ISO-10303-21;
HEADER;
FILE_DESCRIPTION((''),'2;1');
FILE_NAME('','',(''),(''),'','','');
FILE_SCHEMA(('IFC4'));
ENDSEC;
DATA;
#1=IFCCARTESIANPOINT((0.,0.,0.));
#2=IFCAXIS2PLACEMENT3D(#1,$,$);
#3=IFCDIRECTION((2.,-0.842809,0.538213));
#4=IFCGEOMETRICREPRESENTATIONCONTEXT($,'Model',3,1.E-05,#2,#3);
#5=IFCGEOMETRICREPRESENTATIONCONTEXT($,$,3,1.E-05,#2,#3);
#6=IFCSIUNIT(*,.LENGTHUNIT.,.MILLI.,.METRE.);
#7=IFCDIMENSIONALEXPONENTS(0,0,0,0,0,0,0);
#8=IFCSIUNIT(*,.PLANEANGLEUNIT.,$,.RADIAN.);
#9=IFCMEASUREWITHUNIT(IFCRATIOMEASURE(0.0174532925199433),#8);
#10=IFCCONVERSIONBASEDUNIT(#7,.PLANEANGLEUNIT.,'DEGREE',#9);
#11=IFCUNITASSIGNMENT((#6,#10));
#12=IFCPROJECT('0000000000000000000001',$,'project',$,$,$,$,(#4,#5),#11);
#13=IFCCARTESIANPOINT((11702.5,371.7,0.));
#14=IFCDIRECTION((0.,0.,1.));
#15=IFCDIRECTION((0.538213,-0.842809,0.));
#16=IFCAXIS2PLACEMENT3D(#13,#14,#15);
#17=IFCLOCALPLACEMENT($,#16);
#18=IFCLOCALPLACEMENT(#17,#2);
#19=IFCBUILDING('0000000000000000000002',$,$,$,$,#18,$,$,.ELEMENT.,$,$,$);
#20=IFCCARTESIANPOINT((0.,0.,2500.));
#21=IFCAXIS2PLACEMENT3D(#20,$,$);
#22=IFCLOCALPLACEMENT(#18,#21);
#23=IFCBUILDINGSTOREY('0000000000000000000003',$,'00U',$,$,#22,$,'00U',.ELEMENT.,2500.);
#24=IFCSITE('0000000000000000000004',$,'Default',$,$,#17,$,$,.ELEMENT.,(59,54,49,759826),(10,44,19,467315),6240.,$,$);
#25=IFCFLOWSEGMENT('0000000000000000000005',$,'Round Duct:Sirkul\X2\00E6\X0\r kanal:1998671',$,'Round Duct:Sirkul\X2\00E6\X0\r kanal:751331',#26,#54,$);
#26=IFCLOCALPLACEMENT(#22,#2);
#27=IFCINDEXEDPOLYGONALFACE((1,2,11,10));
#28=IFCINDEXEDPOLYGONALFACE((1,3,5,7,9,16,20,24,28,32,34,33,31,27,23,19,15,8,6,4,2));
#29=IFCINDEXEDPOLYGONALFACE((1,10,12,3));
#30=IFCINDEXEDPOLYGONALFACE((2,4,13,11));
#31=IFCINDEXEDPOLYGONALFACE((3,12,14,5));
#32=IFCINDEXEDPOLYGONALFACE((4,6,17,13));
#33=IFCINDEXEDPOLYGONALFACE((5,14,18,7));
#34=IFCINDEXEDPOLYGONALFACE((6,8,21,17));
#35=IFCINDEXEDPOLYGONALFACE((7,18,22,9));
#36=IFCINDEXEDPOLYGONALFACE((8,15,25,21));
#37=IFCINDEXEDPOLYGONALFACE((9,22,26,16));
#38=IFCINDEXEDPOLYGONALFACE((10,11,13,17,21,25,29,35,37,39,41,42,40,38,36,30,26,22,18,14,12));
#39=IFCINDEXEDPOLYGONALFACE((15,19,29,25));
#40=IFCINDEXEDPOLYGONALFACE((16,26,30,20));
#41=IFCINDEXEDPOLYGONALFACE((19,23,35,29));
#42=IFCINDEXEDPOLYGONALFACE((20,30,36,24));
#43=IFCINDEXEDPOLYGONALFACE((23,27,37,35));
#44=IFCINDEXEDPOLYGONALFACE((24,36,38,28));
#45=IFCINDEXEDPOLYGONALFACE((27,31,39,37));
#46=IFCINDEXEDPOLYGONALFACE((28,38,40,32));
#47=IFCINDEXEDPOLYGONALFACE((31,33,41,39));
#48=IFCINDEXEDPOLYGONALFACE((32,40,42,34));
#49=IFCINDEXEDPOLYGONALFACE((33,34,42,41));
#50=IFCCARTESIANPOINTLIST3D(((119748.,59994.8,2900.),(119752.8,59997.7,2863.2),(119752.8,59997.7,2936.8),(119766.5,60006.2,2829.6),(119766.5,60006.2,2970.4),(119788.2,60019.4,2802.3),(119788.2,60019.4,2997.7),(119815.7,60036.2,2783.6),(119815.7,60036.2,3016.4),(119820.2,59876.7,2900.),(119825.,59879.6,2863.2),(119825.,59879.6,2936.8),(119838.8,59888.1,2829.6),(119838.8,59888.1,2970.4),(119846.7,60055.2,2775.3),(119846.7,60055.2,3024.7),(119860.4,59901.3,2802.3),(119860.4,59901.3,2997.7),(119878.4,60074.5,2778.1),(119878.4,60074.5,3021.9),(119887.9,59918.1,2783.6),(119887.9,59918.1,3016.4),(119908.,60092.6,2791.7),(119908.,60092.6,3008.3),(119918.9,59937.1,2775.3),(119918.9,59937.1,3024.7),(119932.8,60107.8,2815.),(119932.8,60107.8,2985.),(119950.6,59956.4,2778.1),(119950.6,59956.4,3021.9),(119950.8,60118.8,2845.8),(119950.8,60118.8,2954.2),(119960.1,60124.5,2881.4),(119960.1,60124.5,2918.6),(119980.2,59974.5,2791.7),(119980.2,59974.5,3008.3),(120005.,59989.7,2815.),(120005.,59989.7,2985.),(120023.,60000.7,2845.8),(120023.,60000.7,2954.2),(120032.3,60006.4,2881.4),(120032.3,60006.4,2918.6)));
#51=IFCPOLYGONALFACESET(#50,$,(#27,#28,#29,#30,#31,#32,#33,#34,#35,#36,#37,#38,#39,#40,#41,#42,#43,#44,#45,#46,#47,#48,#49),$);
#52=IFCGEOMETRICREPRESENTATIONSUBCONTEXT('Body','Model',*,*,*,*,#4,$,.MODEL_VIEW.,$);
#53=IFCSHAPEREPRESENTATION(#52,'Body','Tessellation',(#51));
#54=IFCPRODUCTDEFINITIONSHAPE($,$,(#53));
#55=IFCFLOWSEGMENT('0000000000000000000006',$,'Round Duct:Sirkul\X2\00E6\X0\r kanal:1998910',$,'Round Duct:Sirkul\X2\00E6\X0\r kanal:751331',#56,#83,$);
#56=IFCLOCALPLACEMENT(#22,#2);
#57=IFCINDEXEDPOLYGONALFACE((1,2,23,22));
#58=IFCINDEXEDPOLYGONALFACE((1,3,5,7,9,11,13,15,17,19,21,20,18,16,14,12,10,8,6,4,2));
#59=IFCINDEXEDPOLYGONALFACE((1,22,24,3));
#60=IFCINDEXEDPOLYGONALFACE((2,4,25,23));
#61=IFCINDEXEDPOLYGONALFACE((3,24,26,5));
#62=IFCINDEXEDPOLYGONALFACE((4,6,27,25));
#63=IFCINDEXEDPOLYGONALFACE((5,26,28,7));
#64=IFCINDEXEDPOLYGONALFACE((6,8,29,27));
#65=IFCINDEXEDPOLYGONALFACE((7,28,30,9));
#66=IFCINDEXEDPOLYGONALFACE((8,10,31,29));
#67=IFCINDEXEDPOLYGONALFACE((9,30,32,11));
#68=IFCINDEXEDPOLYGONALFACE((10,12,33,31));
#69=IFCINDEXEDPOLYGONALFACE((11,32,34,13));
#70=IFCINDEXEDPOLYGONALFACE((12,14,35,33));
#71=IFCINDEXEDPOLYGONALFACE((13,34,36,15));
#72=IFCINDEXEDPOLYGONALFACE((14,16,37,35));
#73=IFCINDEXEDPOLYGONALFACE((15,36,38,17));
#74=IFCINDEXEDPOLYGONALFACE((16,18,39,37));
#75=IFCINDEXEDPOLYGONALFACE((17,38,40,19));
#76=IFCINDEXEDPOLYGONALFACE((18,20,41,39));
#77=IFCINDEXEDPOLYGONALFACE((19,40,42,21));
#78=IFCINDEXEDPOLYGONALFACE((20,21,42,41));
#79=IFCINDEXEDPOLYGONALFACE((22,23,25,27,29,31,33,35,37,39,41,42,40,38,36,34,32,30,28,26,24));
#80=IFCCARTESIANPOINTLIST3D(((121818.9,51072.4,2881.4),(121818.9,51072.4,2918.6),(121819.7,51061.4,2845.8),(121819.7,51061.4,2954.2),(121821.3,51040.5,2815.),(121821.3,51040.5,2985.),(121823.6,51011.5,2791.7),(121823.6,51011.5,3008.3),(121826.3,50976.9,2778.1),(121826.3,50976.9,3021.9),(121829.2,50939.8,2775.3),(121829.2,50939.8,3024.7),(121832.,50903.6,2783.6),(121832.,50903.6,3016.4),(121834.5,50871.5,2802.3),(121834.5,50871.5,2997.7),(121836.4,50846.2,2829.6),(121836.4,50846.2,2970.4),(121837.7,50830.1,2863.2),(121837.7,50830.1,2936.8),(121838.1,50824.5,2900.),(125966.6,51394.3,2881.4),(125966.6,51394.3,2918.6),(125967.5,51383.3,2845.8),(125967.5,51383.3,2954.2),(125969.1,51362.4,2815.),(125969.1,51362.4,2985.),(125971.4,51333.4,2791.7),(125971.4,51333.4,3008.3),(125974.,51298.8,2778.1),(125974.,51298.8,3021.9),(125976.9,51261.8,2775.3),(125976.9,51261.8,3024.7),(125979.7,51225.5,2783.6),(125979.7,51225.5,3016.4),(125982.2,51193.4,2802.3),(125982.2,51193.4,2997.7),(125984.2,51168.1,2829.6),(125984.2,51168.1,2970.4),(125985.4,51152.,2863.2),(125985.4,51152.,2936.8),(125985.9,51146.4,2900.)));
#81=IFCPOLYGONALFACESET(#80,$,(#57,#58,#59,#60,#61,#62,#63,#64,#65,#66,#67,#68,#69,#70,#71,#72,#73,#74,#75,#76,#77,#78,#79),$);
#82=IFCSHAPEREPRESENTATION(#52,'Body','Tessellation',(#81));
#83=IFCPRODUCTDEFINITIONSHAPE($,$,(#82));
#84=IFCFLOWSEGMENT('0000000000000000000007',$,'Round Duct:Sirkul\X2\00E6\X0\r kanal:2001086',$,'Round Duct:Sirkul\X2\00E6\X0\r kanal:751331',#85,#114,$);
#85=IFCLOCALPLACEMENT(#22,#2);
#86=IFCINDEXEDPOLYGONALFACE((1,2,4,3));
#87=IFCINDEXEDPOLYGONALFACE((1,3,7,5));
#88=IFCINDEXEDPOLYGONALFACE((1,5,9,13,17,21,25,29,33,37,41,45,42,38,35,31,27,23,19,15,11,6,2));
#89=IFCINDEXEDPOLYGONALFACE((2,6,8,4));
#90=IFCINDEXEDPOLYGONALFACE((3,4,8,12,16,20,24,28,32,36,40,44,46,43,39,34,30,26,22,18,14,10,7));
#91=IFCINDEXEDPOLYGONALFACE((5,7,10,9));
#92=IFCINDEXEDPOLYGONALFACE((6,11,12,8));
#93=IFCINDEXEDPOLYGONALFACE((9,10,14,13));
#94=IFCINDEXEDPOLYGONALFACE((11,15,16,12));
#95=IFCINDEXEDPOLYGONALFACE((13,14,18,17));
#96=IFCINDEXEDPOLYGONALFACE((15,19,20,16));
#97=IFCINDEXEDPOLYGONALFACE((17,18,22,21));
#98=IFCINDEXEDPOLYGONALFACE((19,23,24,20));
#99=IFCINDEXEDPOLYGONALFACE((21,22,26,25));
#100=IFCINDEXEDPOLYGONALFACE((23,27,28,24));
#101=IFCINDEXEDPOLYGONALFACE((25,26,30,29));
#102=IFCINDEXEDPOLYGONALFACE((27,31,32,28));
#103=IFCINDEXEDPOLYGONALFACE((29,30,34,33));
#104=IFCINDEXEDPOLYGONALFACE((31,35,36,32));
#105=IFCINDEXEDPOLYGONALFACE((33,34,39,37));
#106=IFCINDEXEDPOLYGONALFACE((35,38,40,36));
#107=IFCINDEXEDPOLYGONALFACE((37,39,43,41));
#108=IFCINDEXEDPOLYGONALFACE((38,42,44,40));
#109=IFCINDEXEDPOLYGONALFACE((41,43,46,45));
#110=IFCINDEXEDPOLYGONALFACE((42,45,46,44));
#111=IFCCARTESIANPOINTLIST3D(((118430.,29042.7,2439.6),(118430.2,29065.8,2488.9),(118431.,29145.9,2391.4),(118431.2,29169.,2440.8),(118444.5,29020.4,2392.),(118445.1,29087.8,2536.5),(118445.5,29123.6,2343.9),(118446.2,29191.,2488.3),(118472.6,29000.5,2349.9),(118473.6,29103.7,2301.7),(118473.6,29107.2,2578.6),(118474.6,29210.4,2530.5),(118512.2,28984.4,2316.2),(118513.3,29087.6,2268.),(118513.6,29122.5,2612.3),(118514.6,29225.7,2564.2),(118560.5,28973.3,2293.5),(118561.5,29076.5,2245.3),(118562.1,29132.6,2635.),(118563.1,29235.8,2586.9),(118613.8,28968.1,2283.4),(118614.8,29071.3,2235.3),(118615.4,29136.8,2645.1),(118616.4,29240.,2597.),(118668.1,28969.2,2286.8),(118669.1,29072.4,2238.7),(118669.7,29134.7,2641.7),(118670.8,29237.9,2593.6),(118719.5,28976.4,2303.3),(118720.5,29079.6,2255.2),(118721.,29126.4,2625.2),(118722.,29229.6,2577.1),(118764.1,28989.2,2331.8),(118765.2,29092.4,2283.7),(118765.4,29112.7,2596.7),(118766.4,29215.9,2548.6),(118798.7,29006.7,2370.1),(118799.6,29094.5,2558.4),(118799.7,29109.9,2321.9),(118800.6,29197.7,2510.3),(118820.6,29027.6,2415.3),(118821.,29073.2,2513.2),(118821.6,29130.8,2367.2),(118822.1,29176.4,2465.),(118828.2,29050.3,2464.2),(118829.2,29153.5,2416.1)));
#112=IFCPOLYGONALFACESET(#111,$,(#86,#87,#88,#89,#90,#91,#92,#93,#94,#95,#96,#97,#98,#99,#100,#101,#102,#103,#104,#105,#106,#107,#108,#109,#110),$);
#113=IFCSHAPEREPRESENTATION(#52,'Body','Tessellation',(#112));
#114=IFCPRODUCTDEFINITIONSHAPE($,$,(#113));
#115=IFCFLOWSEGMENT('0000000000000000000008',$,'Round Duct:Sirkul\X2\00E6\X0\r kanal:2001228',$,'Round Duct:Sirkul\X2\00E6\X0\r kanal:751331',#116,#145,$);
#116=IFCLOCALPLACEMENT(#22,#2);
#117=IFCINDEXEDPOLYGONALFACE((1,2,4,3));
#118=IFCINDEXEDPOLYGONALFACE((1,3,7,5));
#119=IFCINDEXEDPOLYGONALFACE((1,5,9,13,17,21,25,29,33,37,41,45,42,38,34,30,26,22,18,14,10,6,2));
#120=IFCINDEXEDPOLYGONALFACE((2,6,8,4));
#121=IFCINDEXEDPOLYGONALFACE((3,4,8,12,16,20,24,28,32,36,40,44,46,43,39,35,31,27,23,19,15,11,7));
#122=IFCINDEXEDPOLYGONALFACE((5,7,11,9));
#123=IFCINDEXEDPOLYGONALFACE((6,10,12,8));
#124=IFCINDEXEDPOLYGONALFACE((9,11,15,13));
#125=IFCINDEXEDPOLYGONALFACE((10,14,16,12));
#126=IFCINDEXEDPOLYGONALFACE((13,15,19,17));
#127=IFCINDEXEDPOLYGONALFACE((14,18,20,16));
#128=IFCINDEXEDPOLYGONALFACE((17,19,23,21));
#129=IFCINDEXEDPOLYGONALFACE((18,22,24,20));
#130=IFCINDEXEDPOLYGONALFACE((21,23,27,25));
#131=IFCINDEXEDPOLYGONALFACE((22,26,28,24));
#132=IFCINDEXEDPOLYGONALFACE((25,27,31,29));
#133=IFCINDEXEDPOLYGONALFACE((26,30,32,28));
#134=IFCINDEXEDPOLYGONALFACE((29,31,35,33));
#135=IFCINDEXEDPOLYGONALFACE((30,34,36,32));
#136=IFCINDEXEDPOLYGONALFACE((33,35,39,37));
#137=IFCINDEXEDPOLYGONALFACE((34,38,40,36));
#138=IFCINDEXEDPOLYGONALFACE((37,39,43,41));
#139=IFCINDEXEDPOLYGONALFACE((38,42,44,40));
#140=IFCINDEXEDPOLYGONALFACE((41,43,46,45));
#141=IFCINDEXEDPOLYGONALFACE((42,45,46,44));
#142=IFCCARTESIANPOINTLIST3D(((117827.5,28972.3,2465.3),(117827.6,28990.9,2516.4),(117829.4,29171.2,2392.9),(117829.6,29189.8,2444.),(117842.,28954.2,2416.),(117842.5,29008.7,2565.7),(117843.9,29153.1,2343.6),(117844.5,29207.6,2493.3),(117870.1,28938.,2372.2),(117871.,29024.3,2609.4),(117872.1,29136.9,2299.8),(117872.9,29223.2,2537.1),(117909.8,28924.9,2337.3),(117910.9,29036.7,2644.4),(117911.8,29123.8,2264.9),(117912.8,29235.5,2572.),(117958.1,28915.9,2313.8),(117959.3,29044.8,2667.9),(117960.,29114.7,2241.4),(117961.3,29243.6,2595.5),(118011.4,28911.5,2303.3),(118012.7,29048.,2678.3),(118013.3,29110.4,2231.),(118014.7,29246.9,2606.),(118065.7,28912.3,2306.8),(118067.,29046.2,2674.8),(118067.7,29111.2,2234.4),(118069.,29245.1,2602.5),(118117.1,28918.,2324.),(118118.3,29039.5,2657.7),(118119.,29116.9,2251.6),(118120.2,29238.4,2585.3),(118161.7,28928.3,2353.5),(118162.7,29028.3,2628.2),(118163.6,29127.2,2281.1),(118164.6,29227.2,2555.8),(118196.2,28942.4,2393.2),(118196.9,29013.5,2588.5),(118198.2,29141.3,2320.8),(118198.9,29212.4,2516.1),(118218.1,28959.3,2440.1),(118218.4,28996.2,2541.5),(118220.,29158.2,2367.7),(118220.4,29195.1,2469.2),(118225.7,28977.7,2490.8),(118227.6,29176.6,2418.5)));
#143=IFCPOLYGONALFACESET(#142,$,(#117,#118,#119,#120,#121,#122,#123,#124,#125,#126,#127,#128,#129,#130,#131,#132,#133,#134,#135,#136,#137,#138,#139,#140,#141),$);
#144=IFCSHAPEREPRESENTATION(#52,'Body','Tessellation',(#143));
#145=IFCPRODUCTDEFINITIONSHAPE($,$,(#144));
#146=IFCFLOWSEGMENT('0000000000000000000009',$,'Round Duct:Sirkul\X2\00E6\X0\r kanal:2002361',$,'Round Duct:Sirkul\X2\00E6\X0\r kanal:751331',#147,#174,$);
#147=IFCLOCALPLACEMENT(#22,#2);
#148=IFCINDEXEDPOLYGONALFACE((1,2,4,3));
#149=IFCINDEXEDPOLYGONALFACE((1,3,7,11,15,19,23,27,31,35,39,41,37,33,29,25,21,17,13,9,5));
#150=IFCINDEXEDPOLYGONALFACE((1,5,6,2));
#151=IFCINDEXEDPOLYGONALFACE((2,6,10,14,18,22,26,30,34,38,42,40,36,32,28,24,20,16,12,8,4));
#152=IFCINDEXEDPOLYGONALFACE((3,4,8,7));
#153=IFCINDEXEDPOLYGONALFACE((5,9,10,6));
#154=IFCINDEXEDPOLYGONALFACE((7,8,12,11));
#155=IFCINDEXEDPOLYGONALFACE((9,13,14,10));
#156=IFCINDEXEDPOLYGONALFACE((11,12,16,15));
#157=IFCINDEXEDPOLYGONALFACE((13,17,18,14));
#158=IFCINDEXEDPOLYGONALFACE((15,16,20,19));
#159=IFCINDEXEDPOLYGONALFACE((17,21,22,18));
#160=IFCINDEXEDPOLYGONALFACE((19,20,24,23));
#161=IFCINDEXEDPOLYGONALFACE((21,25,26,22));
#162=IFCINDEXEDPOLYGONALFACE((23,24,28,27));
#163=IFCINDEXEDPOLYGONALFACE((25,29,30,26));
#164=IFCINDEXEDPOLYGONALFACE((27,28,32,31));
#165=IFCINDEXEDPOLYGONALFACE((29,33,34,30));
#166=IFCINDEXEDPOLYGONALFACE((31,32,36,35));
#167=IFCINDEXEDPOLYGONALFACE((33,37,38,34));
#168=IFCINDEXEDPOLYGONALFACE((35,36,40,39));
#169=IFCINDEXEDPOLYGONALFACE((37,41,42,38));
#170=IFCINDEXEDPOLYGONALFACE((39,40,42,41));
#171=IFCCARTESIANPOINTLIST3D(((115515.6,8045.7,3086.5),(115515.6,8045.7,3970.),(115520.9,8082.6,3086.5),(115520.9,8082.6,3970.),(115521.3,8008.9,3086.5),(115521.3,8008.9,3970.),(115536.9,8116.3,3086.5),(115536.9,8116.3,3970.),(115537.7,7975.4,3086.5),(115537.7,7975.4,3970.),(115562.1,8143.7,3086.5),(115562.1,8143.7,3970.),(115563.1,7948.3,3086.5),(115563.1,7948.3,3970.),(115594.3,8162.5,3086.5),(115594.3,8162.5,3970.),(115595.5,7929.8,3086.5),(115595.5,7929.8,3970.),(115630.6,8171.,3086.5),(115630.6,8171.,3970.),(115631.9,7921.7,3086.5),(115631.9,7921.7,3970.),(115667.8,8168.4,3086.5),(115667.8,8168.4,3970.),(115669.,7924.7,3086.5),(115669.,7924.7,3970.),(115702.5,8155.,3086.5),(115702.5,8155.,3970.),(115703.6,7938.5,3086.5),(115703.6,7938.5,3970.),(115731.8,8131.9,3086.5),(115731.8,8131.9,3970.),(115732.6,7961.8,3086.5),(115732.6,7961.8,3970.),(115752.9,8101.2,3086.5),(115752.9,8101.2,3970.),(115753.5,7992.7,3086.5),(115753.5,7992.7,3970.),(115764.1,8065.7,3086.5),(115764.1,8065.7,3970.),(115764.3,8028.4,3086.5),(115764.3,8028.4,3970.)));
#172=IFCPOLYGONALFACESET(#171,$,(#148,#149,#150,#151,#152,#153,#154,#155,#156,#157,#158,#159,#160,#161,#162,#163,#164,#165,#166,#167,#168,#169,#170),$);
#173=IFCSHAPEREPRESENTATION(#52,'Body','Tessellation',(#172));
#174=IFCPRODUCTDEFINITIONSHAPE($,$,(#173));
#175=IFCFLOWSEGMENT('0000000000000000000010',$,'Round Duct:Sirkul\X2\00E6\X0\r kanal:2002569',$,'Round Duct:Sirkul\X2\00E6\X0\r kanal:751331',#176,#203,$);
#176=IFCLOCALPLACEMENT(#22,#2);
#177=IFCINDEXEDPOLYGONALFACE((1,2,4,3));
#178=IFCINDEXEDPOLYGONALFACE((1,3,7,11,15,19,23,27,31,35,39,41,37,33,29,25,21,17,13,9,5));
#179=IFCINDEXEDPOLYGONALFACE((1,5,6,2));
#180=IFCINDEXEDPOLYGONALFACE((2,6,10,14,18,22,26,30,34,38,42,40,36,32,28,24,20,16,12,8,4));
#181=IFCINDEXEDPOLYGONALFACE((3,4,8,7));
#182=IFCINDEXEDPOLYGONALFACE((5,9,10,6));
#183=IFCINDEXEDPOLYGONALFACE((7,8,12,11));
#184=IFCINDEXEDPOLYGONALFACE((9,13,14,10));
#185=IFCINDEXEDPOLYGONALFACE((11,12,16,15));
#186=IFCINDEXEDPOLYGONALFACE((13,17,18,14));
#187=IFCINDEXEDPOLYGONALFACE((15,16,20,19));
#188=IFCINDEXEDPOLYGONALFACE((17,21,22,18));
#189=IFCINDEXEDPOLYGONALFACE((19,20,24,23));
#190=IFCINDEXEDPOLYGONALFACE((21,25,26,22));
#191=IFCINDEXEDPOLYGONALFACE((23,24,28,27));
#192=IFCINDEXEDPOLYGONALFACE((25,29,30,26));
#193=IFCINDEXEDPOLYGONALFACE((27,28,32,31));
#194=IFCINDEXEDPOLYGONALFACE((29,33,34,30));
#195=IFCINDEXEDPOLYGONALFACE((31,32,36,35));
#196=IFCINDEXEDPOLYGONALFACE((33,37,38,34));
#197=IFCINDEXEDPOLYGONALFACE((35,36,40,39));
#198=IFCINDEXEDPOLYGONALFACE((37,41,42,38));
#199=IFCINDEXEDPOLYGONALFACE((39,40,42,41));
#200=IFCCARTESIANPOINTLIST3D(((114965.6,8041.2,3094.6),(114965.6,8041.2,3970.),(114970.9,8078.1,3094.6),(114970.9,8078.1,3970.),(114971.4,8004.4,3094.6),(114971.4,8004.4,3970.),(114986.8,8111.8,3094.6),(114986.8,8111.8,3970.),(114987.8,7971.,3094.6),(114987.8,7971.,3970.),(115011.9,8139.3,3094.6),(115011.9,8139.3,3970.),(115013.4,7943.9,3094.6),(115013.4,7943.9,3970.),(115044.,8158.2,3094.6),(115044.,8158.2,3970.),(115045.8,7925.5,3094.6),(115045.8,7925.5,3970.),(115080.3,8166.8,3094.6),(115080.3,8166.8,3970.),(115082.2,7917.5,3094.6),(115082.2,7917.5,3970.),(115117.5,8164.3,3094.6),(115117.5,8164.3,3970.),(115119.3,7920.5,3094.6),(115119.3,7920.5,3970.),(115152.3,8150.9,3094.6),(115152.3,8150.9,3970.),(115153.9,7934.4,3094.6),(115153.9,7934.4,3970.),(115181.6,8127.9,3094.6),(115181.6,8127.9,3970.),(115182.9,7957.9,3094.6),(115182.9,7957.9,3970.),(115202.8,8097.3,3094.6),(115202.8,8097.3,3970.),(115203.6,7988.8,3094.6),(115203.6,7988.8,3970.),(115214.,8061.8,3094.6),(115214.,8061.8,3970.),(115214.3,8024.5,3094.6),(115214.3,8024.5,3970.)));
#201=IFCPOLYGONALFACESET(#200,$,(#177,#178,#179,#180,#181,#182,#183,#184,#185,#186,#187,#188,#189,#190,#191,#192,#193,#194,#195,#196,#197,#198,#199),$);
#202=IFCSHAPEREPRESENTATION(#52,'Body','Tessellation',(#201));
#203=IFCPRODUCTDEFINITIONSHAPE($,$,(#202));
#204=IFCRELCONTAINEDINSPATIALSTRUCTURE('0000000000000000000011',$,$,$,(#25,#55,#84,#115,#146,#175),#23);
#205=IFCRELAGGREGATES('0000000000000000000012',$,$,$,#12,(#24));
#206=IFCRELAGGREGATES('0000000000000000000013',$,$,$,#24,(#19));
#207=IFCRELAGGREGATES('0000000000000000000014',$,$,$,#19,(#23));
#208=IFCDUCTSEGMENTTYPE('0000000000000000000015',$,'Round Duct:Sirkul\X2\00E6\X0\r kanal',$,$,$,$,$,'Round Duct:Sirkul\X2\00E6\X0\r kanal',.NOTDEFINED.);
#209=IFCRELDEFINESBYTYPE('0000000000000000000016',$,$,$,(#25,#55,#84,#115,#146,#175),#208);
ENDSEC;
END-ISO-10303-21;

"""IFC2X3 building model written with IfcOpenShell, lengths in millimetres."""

from ifc_helpers import new_model, entity, si_unit, converted_unit, direction, frame, frame_2d, origin, origin_2d_with_axis, place, context, subcontext, project, spatial, circle, extrude, type_object, element, save


model = new_model("IFC2X3")

# Units and contexts
model_context = context("Model", 3, precision=1e-05, world=origin(), true_north=direction((2.0, -0.842809, 0.538213)))
context_of_model = context(None, 3, precision=1e-05, world=origin(), true_north=direction((2.0, -0.842809, 0.538213)))
body_context = subcontext(model_context, "Body", "Model", "MODEL_VIEW")
ifc_project = project(units=[si_unit("LENGTHUNIT", "METRE", prefix="MILLI"), converted_unit("PLANEANGLEUNIT", "DEGREE", entity("IfcRatioMeasure", 0.0174532925199433), si_unit("PLANEANGLEUNIT", "RADIAN"), dimensions=[0, 0, 0, 0, 0, 0, 0])], contexts=[model_context, context_of_model])

# Site, building, storey
site_placement = place(None, frame((11702.5, 371.7, 0.0), z_axis=(0.0, 0.0, 1.0), x_axis=(0.538213, -0.842809, 0.0)))
site = spatial("IfcSite", under=ifc_project, at=site_placement, Name="Default", CompositionType="ELEMENT", RefLatitude=(59, 54, 49, 759826), RefLongitude=(10, 44, 19, 467315), RefElevation=6240.0)
building_placement = place(site_placement, origin())
building = spatial("IfcBuilding", under=site, at=building_placement, CompositionType="ELEMENT")
storey_placement = place(building_placement, frame((0.0, 0.0, 2500.0)))
storey = spatial("IfcBuildingStorey", under=building, at=storey_placement, Name="00U", LongName="00U", CompositionType="ELEMENT", Elevation=2500.0)

# Flow segments
duct_segment_type_1 = type_object("IfcDuctSegmentType", Name="Round Duct:Sirkulær kanal", ElementType="Round Duct:Sirkulær kanal", PredefinedType="NOTDEFINED")
flow_segment_1_placement = place(storey_placement, origin())
element("IfcFlowSegment", 1, at=flow_segment_1_placement, inside=storey, type_object=duct_segment_type_1, Name="Round Duct:Sirkulær kanal:1998671", ObjectType="Round Duct:Sirkulær kanal:751331", context=body_context, shape_type="SweptSolid", body=[
    extrude(circle(Radius=125.0, at=origin_2d_with_axis()), frame((119854.7, 60060.0, 2900.0), z_axis=(0.521574, -0.853206, 0.0), x_axis=(-0.853206, -0.521574, 0.0)), (0.0, 0.0, 1.0), 138.4),
])
flow_segment_2_placement = place(storey_placement, origin())
element("IfcFlowSegment", 2, at=flow_segment_2_placement, inside=storey, type_object=duct_segment_type_1, Name="Round Duct:Sirkulær kanal:1998910", ObjectType="Round Duct:Sirkulær kanal:751331", context=body_context, shape_type="SweptSolid", body=[
    extrude(circle(Radius=125.0, at=origin_2d_with_axis()), frame((121828.4, 50949.2, 2900.0), z_axis=(0.997002, 0.077379, 0.0), x_axis=(0.077379, -0.997002, 0.0)), (0.0, 0.0, 1.0), 4160.2),
])
flow_segment_3_placement = place(storey_placement, origin())
element("IfcFlowSegment", 3, at=flow_segment_3_placement, inside=storey, type_object=duct_segment_type_1, Name="Round Duct:Sirkulær kanal:2001086", ObjectType="Round Duct:Sirkulær kanal:751331", context=body_context, shape_type="SweptSolid", body=[
    extrude(circle(Radius=200.0, at=origin_2d_with_axis()), frame((118628.2, 29052.3, 2464.2), z_axis=(0.008891, 0.906264, -0.422618), x_axis=(0.999952, -0.00981, 0.0)), (0.0, 0.0, 1.0), 113.9),
])
flow_segment_4_placement = place(storey_placement, origin())
element("IfcFlowSegment", 4, at=flow_segment_4_placement, inside=storey, type_object=duct_segment_type_1, Name="Round Duct:Sirkulær kanal:2001228", ObjectType="Round Duct:Sirkulær kanal:751331", context=body_context, shape_type="SweptSolid", body=[
    extrude(circle(Radius=200.0, at=frame_2d((0.0, 0.0), x_axis=(1.0, 0.0))), frame((118025.7, 28979.7, 2490.8), z_axis=(0.009219, 0.939647, -0.34202), x_axis=(0.999952, -0.00981, 0.0)), (0.0, 0.0, 1.0), 211.7),
])
flow_segment_5_placement = place(storey_placement, origin())
element("IfcFlowSegment", 5, at=flow_segment_5_placement, inside=storey, type_object=duct_segment_type_1, Name="Round Duct:Sirkulær kanal:2002361", ObjectType="Round Duct:Sirkulær kanal:751331", context=body_context, shape_type="SweptSolid", body=[
    extrude(circle(Radius=125.0, at=frame_2d((0.0, 0.0), x_axis=(1.0, 0.0))), frame((115640.6, 8046.4, 3086.5), z_axis=(0.000001, 0.0, 1.0), x_axis=(-0.954042, -0.299672, 0.000001)), (0.0, 0.0, 1.0), 883.5),
])
flow_segment_6_placement = place(storey_placement, origin())
element("IfcFlowSegment", 6, at=flow_segment_6_placement, inside=storey, type_object=duct_segment_type_1, Name="Round Duct:Sirkulær kanal:2002569", ObjectType="Round Duct:Sirkulær kanal:751331", context=body_context, shape_type="SweptSolid", body=[
    extrude(circle(Radius=125.0, at=origin_2d_with_axis()), frame((115090.6, 8042.2, 3094.6), z_axis=(0.000001, 0.0, 1.0), x_axis=(-0.999971, -0.007643, 0.000001)), (0.0, 0.0, 1.0), 875.4),
])

save(model, "model.ifc")
